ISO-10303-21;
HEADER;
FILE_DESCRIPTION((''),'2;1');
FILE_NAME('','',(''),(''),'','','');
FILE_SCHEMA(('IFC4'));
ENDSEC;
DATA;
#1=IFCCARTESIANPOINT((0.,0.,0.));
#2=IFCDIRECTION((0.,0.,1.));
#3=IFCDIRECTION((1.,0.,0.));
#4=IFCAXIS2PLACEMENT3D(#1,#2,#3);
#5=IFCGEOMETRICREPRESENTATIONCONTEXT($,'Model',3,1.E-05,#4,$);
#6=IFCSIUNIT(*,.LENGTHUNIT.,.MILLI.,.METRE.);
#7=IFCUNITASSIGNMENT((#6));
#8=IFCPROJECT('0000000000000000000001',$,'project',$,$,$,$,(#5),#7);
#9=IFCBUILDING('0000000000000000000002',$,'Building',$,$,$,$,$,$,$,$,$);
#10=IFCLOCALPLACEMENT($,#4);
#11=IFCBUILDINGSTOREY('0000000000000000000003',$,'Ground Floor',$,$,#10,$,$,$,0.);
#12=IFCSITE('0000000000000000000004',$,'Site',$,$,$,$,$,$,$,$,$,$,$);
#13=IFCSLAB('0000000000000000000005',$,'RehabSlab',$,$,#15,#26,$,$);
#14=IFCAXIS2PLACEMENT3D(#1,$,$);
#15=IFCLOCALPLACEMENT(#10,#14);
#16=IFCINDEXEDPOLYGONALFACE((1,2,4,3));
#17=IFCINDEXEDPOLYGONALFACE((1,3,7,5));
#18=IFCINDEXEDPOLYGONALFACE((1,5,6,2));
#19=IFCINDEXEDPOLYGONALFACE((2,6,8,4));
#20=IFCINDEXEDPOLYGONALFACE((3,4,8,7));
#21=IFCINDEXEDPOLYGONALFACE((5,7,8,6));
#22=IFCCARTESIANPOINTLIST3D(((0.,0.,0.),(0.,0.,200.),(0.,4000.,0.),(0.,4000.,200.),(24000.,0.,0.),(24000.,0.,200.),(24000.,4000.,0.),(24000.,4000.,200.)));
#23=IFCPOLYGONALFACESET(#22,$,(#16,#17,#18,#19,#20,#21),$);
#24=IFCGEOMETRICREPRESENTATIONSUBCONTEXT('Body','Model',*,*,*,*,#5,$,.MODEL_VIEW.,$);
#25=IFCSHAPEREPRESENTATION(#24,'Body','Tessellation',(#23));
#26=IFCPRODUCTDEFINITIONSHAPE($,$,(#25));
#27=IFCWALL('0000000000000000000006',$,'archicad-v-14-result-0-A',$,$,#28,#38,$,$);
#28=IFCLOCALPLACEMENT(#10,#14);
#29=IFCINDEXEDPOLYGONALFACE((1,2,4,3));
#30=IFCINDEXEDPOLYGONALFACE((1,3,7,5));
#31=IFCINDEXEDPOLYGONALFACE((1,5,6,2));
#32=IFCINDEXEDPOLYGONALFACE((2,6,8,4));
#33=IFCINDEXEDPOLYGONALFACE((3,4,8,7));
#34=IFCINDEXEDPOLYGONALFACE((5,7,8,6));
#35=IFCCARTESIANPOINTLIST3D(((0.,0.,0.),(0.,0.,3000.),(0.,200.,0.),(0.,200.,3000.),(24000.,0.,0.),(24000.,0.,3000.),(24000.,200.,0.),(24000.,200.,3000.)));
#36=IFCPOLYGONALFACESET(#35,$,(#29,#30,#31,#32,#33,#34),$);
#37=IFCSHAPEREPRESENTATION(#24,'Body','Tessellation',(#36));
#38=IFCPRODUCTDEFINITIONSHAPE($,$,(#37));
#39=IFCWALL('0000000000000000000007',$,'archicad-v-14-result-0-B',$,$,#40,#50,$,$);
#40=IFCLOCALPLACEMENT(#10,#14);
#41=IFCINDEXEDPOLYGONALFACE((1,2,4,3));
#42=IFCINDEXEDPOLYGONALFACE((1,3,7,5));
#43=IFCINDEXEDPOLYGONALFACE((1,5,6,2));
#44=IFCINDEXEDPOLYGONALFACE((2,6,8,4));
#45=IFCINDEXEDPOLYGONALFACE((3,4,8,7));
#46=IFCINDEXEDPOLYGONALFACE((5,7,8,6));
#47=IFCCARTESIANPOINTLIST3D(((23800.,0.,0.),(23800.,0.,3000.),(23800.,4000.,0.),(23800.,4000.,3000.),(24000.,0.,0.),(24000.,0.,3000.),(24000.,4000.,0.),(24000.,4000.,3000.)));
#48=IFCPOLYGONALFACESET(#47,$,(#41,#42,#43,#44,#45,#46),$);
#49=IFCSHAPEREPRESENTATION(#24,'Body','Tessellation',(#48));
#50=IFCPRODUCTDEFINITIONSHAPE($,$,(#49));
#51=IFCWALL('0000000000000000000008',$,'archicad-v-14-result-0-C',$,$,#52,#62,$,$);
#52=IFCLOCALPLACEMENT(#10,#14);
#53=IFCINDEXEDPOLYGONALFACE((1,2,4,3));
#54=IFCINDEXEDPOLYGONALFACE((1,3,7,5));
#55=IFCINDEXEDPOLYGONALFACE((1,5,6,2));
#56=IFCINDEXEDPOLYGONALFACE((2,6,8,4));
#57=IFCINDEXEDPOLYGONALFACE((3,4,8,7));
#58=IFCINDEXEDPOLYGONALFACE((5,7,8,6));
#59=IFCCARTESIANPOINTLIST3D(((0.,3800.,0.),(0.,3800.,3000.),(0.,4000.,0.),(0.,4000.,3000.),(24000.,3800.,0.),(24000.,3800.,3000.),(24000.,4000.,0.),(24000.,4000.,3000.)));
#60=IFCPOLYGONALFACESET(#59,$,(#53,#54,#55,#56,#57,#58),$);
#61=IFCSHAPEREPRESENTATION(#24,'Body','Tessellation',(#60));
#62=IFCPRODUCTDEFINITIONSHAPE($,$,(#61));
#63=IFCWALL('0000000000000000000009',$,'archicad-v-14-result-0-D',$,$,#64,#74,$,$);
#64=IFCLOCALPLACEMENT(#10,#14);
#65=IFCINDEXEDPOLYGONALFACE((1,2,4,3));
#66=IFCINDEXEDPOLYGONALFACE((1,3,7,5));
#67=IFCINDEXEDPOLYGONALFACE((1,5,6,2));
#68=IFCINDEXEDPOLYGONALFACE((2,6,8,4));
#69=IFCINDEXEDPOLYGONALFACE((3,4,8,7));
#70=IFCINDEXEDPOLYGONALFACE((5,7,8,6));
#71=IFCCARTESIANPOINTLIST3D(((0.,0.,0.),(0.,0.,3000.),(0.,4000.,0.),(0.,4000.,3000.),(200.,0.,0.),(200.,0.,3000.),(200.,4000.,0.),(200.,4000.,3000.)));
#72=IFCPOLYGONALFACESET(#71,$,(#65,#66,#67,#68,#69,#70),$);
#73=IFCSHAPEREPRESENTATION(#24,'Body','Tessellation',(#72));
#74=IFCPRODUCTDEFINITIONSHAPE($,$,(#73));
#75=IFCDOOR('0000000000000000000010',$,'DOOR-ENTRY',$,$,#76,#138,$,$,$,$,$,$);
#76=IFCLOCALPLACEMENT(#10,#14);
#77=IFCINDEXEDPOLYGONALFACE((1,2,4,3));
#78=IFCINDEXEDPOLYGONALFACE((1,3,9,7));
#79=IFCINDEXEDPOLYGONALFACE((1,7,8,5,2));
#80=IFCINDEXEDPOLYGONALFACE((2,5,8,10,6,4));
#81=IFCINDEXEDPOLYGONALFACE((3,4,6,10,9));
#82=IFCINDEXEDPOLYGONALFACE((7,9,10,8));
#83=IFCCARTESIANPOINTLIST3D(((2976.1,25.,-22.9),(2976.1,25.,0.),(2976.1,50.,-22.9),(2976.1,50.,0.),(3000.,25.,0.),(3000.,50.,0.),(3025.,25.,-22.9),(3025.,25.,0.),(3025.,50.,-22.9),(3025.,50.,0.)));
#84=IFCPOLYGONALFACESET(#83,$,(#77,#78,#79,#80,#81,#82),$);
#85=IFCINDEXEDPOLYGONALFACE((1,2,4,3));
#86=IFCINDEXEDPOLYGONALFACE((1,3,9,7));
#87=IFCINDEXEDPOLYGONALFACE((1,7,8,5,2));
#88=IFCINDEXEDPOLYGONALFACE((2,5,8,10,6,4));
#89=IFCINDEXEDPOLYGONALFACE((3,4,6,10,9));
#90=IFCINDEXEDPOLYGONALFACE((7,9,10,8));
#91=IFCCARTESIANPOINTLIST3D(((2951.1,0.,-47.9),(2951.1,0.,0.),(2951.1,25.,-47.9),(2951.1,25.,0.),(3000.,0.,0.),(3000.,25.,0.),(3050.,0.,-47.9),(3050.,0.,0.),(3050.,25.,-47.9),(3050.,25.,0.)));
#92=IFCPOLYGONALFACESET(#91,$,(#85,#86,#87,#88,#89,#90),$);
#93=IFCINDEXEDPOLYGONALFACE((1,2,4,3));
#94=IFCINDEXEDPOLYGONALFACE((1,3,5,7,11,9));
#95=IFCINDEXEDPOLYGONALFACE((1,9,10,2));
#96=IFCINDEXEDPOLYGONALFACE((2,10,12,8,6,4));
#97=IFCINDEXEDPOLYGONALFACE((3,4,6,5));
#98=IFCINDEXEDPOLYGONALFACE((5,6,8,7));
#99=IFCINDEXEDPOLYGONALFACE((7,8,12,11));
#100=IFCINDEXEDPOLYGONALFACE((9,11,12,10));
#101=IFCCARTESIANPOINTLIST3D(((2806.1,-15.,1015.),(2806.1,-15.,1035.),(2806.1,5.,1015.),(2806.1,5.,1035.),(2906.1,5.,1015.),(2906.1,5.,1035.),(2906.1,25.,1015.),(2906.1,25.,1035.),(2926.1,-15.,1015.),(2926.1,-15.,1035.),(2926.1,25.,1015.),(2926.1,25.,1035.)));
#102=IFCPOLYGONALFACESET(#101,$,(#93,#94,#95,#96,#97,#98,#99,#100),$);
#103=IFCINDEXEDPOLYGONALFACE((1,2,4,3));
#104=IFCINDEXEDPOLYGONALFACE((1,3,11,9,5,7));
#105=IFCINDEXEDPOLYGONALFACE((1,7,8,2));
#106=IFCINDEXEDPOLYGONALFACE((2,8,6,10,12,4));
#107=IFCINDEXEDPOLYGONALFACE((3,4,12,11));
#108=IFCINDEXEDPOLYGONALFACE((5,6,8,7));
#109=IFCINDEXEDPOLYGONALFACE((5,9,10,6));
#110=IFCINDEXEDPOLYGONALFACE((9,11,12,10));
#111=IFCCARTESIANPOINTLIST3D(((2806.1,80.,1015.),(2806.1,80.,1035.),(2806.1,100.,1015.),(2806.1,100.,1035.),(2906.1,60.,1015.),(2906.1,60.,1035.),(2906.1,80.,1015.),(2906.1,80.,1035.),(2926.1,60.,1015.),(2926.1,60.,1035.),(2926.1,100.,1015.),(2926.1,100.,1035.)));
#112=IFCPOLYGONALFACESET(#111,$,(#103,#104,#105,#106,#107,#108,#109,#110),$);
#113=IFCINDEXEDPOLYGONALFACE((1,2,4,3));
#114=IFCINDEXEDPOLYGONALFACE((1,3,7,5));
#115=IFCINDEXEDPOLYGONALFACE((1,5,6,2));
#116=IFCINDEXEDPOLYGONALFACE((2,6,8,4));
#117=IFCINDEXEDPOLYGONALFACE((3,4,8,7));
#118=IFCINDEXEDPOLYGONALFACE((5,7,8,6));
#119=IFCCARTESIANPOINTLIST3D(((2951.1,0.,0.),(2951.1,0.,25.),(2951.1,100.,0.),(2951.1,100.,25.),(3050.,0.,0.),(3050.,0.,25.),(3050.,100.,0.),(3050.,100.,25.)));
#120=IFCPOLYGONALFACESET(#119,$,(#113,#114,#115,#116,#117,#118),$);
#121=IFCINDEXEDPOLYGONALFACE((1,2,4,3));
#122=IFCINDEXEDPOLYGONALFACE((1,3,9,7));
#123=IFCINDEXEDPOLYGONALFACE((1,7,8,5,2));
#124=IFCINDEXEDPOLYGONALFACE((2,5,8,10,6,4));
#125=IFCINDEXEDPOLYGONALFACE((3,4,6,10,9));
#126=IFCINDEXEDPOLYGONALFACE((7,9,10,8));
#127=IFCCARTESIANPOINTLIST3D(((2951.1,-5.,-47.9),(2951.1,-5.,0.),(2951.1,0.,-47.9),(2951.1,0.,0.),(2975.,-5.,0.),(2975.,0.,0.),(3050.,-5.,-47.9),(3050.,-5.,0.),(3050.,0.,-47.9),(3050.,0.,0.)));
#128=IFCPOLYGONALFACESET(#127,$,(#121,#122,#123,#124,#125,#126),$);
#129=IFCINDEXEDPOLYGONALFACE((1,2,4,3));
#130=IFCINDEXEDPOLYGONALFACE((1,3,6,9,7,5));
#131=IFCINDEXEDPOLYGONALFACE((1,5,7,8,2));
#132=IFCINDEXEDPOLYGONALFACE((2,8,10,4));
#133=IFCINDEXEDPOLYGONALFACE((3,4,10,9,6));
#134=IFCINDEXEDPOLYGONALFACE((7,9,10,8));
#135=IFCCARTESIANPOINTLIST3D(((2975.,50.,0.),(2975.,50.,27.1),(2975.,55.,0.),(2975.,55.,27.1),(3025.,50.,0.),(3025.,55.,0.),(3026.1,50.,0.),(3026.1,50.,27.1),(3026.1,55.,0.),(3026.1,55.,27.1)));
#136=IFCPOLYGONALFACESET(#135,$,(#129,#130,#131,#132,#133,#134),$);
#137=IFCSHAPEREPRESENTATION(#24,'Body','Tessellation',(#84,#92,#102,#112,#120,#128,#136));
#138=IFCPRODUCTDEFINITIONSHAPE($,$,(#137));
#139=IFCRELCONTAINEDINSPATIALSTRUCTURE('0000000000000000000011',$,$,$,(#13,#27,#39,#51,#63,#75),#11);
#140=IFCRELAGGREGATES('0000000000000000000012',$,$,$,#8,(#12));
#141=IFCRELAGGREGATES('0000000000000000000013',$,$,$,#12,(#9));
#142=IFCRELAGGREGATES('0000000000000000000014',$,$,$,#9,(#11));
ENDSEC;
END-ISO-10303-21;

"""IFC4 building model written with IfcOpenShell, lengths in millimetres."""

from ifc_helpers import new_model, si_unit, frame, origin_with_axes, place, context, subcontext, project, spatial, line, indexed_curve, outline, extrude, element, save


model = new_model("IFC4")

# Units and contexts
model_context = context("Model", 3, precision=1e-05, world=origin_with_axes())
body_context = subcontext(model_context, "Body", "Model", "MODEL_VIEW")
ifc_project = project(units=[si_unit("LENGTHUNIT", "METRE", prefix="MILLI")], contexts=[model_context])

# Site, building, storey
site = spatial("IfcSite", under=ifc_project, Name="Site")
building = spatial("IfcBuilding", under=site, Name="Building")
storey_placement = place(None, origin_with_axes())
storey = spatial("IfcBuildingStorey", under=building, at=storey_placement, Name="Ground Floor", Elevation=0.0)

# Slab
slab_placement = place(storey_placement, origin_with_axes())
element("IfcSlab", 1, at=slab_placement, inside=storey, Name="RehabSlab", context=body_context, shape_type="SweptSolid", body=[
    extrude(outline(indexed_curve([(0.0, 0.0), (24000.0, 0.0), (24000.0, 4000.0), (0.0, 4000.0), (0.0, 0.0)])), None, (0.0, 0.0, 1.0), 200.0),
])

# Walls
wall_1_placement = place(storey_placement, origin_with_axes())
element("IfcWall", 2, at=wall_1_placement, inside=storey, Name="archicad-v-14-result-0-A", context=body_context, shape_type="SweptSolid", body=[
    extrude(outline(indexed_curve([(0.0, 0.0), (0.0, 200.0), (24000.0, 200.0), (24000.0, 0.0), (0.0, 0.0)], self_intersect=False)), origin_with_axes(), (0.0, 0.0, 1.0), 3000.0),
])
wall_2_placement = place(storey_placement, frame((24000.0, 0.0, 0.0), z_axis=(0.0, 0.0, 1.0), x_axis=(0.0, 1.0, 0.0)))
element("IfcWall", 3, at=wall_2_placement, inside=storey, Name="archicad-v-14-result-0-B", context=body_context, shape_type="SweptSolid", body=[
    extrude(outline(indexed_curve([(0.0, 0.0), (0.0, 200.0), (4000.0, 200.0), (4000.0, 0.0), (0.0, 0.0)], self_intersect=False)), origin_with_axes(), (0.0, 0.0, 1.0), 3000.0),
])
wall_3_placement = place(storey_placement, frame((24000.0, 4000.0, 0.0), z_axis=(0.0, 0.0, 1.0), x_axis=(-1.0, 0.0, 0.0)))
element("IfcWall", 4, at=wall_3_placement, inside=storey, Name="archicad-v-14-result-0-C", context=body_context, shape_type="SweptSolid", body=[
    extrude(outline(indexed_curve([(0.0, 0.0), (0.0, 200.0), (24000.0, 200.0), (24000.0, 0.0), (0.0, 0.0)], self_intersect=False)), origin_with_axes(), (0.0, 0.0, 1.0), 3000.0),
])
wall_4_placement = place(storey_placement, frame((0.0, 4000.0, 0.0), z_axis=(0.0, 0.0, 1.0), x_axis=(0.0, -1.0, 0.0)))
element("IfcWall", 5, at=wall_4_placement, inside=storey, Name="archicad-v-14-result-0-D", context=body_context, shape_type="SweptSolid", body=[
    extrude(outline(indexed_curve([(0.0, 0.0), (0.0, 200.0), (4000.0, 200.0), (4000.0, 0.0), (0.0, 0.0)], self_intersect=False)), origin_with_axes(), (0.0, 0.0, 1.0), 3000.0),
])

# Door
door_1_placement = place(storey_placement, frame((3000.0, 0.0, 0.0), z_axis=(0.0, 0.0, 1.0), x_axis=(1.0, 0.0, 0.0)))
element("IfcDoor", 6, at=door_1_placement, inside=storey, Name="DOOR-ENTRY", context=body_context, shape_type="SweptSolid", body=[
    extrude(outline(indexed_curve([(0.0, 0.0), (0.0, 2.1), (1.1, 2.1), (1.1, 0.0), (-23.9, 0.0), (-23.9, -22.9), (25.0, -22.9), (25.0, 0.0)], segments=[line(1, 2, 3, 4, 5, 6, 7, 8, 1)])), frame((0.0, 25.0, 0.0), z_axis=(0.0, -1.0, 0.0), x_axis=(1.0, 0.0, 0.0)), (0.0, 0.0, -1.0), 25.0),
    extrude(outline(indexed_curve([(0.0, 0.0), (0.0, 2.1), (1.1, 2.1), (1.1, 0.0), (-48.9, 0.0), (-48.9, -47.9), (50.0, -47.9), (50.0, 0.0)], segments=[line(1, 2, 3, 4, 5, 6, 7, 8, 1)])), frame((0.0, 0.0, 0.0), z_axis=(0.0, -1.0, 0.0), x_axis=(1.0, 0.0, 0.0)), (0.0, 0.0, -1.0), 25.0),
    extrude(outline(indexed_curve([(0.0, 0.0), (-48.9, 0.0), (-48.9, 35.0), (0.0, 35.0)], segments=[line(1, 2, 3, 4, 1)])), frame((25.0, 25.0, 25.0), z_axis=(0.0, 0.0, 1.0), x_axis=(1.0, 0.0, 0.0)), (0.0, 0.0, 1.0), -47.9),
    extrude(outline(indexed_curve([(0.0, 0.0), (0.0, -40.0), (-120.0, -40.0), (-120.0, -20.0), (-20.0, -20.0), (-20.0, 0.0)], segments=[line(1, 2, 3, 4, 5, 6, 1)])), frame((-73.9, 25.0, 1015.0), z_axis=(0.0, 0.0, 1.0), x_axis=(1.0, 0.0, 0.0)), (0.0, 0.0, 1.0), 20.0),
    extrude(outline(indexed_curve([(0.0, 0.0), (0.0, 40.0), (-120.0, 40.0), (-120.0, 20.0), (-20.0, 20.0), (-20.0, 0.0)], segments=[line(1, 2, 3, 4, 5, 6, 1)])), frame((-73.9, 60.0, 1015.0), z_axis=(0.0, 0.0, 1.0), x_axis=(1.0, 0.0, 0.0)), (0.0, 0.0, 1.0), 20.0),
    extrude(outline(indexed_curve([(0.0, 0.0), (-98.9, 0.0), (-98.9, 100.0), (0.0, 100.0)], segments=[line(1, 2, 3, 4, 1)])), frame((50.0, 0.0, 0.0), z_axis=(0.0, 0.0, 1.0), x_axis=(1.0, 0.0, 0.0)), (0.0, 0.0, 1.0), 25.0),
    extrude(outline(indexed_curve([(0.0, 0.0), (0.0, 27.1), (51.1, 27.1), (51.1, 0.0), (-23.9, 0.0), (-23.9, -47.9), (75.0, -47.9), (75.0, 0.0)], segments=[line(1, 2, 3, 4, 5, 6, 7, 8, 1)])), frame((-25.0, -5.0, 0.0), z_axis=(0.0, -1.0, 0.0), x_axis=(1.0, 0.0, 0.0)), (0.0, 0.0, -1.0), 5.0),
    extrude(outline(indexed_curve([(0.0, 0.0), (0.0, 27.1), (51.1, 27.1), (51.1, 0.0), (1.1, 0.0), (1.1, -22.9), (50.0, -22.9), (50.0, 0.0)], segments=[line(1, 2, 3, 4, 5, 6, 7, 8, 1)])), frame((-25.0, 50.0, 0.0), z_axis=(0.0, -1.0, 0.0), x_axis=(1.0, 0.0, 0.0)), (0.0, 0.0, -1.0), 5.0),
])

save(model, "model.ifc")
